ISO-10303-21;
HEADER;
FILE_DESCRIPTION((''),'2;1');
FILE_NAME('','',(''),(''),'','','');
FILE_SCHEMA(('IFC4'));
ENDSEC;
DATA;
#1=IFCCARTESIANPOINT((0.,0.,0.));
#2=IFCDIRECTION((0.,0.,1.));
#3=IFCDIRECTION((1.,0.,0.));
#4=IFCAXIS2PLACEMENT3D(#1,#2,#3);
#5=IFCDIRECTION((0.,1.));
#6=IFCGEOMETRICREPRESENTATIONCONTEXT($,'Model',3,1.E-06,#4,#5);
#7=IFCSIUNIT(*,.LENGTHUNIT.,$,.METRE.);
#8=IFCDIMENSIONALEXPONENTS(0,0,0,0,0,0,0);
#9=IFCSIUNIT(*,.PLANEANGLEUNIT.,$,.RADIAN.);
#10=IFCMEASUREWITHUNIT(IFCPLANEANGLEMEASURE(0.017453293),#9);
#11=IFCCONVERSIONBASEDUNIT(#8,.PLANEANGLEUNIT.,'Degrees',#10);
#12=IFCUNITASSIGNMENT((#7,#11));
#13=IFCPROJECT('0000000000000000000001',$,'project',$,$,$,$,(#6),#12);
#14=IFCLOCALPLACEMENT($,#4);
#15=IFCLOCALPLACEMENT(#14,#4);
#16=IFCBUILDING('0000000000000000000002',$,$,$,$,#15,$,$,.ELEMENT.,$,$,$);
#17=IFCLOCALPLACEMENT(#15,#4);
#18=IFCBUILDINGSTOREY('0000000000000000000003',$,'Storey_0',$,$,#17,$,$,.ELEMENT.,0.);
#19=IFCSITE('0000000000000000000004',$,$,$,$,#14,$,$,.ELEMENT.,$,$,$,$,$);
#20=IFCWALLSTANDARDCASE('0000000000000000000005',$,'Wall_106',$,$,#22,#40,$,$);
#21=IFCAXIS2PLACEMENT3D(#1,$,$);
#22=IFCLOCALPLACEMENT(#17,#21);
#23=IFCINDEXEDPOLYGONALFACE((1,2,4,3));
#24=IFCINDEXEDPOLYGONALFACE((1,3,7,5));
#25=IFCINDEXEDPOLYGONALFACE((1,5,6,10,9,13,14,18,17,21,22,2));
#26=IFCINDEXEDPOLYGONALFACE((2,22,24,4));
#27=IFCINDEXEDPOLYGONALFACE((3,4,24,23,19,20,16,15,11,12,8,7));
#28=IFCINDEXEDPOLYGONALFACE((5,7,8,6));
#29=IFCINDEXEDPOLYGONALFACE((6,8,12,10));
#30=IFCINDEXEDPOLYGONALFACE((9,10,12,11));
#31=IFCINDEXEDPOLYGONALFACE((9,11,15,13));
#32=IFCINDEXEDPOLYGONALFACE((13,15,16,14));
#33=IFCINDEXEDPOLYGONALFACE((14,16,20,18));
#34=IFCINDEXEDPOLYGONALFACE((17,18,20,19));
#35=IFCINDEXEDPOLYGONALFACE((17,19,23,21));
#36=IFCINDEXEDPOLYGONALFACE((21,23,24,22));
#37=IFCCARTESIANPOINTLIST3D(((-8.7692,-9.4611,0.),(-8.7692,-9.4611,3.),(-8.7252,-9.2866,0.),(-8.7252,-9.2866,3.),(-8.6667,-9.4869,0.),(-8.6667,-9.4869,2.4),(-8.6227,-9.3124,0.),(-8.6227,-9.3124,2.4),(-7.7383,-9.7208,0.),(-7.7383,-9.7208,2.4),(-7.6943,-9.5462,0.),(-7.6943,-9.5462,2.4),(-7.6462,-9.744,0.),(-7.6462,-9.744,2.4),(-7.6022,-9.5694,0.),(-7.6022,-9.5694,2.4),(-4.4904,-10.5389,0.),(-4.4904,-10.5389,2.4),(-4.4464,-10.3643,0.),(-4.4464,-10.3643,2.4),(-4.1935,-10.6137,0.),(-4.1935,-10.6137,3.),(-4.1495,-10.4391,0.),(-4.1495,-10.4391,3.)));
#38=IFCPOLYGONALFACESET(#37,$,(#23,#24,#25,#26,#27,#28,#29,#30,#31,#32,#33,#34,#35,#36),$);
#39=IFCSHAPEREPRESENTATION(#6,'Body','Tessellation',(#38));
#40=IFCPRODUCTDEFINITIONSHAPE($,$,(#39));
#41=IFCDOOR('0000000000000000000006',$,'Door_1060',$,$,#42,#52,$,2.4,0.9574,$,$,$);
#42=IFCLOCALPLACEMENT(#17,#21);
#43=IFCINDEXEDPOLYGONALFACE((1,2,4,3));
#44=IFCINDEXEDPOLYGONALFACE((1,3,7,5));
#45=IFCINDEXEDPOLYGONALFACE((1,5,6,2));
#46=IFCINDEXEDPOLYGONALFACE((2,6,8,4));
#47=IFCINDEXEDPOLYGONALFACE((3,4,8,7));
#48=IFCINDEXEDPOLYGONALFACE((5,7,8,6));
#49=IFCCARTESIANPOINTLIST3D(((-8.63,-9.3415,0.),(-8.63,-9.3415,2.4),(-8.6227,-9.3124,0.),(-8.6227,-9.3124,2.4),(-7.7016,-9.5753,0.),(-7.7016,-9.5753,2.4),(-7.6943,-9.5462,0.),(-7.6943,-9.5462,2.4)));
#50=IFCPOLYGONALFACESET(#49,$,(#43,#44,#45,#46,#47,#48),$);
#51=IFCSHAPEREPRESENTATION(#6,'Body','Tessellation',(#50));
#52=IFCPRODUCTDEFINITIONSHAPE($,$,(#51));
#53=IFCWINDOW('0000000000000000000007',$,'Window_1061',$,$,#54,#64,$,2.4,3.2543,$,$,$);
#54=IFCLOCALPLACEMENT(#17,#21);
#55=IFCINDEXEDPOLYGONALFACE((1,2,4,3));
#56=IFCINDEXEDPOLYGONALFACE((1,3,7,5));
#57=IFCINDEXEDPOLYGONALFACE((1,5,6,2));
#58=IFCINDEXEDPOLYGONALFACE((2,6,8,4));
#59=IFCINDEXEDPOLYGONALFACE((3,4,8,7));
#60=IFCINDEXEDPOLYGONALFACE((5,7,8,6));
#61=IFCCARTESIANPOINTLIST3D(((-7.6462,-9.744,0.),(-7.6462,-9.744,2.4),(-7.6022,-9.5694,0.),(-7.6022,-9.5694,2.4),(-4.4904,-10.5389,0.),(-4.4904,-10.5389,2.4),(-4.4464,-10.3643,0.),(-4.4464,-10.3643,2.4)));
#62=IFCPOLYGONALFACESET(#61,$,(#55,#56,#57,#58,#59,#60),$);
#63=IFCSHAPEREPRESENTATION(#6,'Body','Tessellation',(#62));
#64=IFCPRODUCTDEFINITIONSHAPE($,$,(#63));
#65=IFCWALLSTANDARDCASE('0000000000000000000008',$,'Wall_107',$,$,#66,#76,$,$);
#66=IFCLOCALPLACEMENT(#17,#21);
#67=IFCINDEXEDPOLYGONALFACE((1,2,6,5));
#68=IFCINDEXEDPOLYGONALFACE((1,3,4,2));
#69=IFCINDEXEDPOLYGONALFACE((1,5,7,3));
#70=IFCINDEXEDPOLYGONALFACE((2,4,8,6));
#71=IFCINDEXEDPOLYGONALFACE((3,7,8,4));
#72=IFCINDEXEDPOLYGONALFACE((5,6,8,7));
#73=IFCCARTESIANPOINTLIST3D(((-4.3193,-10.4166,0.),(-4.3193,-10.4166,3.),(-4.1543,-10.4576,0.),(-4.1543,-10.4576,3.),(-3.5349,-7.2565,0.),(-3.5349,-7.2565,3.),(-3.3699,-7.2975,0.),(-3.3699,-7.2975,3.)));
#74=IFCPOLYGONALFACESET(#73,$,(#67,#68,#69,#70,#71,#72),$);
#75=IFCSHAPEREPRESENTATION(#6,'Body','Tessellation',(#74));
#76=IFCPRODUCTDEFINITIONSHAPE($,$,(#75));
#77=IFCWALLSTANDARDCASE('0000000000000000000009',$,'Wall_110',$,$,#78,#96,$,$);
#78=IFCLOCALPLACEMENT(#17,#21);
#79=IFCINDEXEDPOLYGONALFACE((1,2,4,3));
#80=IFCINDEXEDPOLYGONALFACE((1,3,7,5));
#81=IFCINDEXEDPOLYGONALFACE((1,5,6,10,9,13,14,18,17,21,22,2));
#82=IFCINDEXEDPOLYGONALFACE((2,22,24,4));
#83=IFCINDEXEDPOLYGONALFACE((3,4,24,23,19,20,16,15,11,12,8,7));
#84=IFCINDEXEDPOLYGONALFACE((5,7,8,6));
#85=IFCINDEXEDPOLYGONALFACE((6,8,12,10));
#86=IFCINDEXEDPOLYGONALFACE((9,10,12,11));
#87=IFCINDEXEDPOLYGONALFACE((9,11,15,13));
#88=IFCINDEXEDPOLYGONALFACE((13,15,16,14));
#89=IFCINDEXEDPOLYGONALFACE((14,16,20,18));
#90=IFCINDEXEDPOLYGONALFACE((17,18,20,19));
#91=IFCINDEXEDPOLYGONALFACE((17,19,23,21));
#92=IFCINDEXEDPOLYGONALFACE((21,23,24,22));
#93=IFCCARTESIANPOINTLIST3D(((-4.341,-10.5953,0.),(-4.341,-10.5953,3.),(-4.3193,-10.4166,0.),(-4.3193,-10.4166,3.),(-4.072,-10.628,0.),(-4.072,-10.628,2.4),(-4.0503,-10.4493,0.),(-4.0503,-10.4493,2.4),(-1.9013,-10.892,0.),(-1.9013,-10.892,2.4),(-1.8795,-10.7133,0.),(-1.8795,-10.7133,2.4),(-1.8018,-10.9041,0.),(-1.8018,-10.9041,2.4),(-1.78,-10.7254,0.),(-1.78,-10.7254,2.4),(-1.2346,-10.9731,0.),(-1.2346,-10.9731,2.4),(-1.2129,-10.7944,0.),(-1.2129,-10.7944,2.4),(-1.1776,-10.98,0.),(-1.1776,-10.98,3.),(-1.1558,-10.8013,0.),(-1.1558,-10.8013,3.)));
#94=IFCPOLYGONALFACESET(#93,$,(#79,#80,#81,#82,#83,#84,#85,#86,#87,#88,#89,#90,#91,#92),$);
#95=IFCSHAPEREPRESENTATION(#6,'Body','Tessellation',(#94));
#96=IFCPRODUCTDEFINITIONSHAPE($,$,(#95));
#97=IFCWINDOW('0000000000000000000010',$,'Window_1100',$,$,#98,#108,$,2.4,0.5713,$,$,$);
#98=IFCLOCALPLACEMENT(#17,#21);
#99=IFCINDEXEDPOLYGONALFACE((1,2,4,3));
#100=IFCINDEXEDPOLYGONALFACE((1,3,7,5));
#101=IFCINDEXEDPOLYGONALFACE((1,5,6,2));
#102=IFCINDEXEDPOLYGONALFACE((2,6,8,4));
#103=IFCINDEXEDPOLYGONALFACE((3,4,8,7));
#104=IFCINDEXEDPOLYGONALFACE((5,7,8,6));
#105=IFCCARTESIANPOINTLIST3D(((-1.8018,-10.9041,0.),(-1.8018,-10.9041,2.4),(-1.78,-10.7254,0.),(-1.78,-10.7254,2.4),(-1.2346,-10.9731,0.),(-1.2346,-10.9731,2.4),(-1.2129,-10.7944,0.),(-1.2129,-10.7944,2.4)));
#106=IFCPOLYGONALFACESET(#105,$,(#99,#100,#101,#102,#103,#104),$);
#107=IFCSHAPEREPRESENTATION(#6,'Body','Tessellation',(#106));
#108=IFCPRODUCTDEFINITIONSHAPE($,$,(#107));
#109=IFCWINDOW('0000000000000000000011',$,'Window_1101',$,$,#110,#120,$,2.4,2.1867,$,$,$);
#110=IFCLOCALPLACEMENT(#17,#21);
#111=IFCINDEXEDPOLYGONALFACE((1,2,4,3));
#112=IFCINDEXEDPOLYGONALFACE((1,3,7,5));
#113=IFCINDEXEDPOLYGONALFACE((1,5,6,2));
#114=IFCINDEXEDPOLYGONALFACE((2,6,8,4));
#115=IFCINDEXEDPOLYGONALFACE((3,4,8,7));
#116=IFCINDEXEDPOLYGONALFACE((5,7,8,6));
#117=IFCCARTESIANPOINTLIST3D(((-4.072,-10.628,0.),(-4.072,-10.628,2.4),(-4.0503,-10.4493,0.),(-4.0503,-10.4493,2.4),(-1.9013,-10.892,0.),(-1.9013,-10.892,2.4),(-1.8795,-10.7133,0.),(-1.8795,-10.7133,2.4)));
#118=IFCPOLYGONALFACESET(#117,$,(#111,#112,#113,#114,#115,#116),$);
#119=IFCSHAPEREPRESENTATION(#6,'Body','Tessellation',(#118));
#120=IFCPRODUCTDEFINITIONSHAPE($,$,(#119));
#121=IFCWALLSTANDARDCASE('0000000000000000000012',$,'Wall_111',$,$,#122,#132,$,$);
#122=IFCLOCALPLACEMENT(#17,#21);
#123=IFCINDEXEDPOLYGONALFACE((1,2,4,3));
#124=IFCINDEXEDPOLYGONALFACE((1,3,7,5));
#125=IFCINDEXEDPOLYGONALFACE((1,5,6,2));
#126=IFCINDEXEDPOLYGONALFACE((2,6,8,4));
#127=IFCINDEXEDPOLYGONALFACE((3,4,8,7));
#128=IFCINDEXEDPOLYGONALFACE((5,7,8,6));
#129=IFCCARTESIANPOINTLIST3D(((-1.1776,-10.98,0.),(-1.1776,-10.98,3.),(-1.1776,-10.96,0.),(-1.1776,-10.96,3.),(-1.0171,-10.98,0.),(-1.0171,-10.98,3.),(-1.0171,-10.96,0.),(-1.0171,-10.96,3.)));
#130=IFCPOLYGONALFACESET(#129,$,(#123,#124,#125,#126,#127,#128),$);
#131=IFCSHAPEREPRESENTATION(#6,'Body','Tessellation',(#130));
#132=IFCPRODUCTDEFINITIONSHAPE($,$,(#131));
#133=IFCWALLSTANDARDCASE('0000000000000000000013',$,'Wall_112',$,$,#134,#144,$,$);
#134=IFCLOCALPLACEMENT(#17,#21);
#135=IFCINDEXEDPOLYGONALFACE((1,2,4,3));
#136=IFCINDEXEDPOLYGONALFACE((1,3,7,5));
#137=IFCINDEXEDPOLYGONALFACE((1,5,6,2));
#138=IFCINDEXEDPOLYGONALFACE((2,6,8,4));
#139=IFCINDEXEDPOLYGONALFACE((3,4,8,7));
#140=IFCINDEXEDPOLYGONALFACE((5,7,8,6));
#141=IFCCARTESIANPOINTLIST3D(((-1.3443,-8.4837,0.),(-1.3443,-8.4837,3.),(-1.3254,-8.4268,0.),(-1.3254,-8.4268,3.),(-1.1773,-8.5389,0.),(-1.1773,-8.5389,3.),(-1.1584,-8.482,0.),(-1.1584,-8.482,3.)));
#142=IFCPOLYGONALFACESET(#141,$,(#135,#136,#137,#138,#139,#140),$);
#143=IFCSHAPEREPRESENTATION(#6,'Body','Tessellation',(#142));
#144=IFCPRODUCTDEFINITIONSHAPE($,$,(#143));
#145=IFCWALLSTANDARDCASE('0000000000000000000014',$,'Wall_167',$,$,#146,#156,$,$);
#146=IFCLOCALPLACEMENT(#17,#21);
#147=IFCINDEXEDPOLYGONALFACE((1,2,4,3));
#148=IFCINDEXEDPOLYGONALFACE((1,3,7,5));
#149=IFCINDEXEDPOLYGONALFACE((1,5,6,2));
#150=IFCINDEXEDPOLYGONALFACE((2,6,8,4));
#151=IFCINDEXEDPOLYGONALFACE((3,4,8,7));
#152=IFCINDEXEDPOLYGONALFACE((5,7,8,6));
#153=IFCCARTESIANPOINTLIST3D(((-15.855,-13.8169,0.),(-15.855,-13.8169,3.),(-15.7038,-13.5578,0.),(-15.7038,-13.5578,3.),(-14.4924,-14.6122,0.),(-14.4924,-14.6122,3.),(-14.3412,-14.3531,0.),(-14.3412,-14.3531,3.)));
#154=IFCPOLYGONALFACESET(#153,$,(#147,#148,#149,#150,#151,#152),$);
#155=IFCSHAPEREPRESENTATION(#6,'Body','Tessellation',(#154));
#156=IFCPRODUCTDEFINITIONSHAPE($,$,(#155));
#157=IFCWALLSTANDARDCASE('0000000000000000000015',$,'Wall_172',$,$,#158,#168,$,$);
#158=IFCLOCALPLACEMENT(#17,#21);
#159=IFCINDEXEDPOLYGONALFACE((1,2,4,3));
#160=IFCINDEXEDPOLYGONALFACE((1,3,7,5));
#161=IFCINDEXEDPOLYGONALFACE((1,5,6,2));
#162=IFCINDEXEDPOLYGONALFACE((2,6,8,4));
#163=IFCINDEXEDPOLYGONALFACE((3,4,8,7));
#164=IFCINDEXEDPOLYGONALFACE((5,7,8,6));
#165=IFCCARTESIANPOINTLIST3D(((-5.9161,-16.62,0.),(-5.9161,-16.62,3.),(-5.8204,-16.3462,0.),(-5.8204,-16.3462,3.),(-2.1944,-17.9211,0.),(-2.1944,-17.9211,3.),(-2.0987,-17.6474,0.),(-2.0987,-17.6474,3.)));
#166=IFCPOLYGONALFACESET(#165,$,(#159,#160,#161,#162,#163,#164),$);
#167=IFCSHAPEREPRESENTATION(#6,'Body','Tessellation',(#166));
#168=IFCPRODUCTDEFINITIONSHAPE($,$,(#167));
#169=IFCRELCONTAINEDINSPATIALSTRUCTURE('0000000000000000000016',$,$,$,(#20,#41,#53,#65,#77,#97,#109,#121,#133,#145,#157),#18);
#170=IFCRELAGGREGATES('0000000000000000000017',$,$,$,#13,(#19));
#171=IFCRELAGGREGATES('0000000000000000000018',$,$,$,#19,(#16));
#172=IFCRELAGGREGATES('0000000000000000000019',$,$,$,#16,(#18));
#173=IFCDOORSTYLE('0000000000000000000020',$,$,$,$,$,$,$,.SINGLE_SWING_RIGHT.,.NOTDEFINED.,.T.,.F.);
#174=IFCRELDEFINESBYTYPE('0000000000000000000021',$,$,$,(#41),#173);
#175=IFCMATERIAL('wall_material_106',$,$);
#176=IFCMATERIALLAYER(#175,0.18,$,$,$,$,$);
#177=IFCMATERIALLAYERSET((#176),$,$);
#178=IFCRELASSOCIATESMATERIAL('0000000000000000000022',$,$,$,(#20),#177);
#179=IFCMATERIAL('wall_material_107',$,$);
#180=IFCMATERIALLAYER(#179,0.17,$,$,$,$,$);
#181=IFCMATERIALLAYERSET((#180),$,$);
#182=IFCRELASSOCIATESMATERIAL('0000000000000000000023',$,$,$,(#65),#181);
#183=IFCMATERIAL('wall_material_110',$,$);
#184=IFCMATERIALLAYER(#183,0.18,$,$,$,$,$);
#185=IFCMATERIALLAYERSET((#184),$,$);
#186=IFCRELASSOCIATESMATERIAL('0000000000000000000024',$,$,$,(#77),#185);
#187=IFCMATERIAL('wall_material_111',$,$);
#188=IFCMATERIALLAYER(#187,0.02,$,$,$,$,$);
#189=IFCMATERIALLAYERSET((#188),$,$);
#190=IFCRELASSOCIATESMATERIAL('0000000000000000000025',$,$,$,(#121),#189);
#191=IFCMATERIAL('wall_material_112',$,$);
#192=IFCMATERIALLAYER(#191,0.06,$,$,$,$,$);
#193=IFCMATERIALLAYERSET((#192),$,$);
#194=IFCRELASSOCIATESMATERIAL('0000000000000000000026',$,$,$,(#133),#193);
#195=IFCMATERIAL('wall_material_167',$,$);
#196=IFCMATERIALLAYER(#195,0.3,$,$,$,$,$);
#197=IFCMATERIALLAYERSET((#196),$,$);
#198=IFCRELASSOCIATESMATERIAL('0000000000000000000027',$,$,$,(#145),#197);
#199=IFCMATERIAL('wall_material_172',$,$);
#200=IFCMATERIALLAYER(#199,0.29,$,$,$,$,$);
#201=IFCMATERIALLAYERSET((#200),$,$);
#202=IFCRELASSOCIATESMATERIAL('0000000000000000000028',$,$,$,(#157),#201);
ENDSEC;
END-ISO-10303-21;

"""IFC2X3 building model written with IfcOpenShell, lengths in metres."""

from ifc_helpers import new_model, entity, si_unit, converted_unit, direction, frame, frame_2d, origin_with_axes, place, context, project, spatial, polyline, rectangle, outline, extrude, material, layer, layer_set, layer_usage, type_object, element, fill, save


model = new_model("IFC2X3")

# Units and contexts
model_context = context("Model", 3, precision=1e-06, world=origin_with_axes(), true_north=direction((0.0, 1.0)))
ifc_project = project(units=[si_unit("LENGTHUNIT", "METRE"), converted_unit("PLANEANGLEUNIT", "Degrees", entity("IfcPlaneAngleMeasure", 0.017453293), si_unit("PLANEANGLEUNIT", "RADIAN"), dimensions=[0, 0, 0, 0, 0, 0, 0])], contexts=[model_context])

# Site, building, storey
site_placement = place(None, origin_with_axes())
site = spatial("IfcSite", under=ifc_project, at=site_placement, CompositionType="ELEMENT")
building_placement = place(site_placement, origin_with_axes())
building = spatial("IfcBuilding", under=site, at=building_placement, CompositionType="ELEMENT")
storey_placement = place(building_placement, origin_with_axes())
storey = spatial("IfcBuildingStorey", under=building, at=storey_placement, Name="Storey_0", CompositionType="ELEMENT", Elevation=0.0)

# Wall, openings, door, window
ifc_material_1 = material(Name="wall_material_106")
ifc_layer_1 = layer(ifc_material_1, 0.18)
ifc_layer_set_1 = layer_set([ifc_layer_1])
ifc_layer_usage_1 = layer_usage(ifc_layer_set_1, "AXIS2", "POSITIVE", 0.0)
wall_1_placement = place(storey_placement, frame((-8.7692, -9.4611, 0.0), z_axis=(0.0, 0.0, 1.0), x_axis=(0.96971, -0.244257, 0.0)))
wall_1 = element("IfcWallStandardCase", 1, at=wall_1_placement, inside=storey, material=ifc_layer_usage_1, Name="Wall_106", context=model_context, shape_type="SweptSolid", body=[
    extrude(outline(polyline([(0.0, 0.18), (4.7186, 0.18), (4.7186, 0.0), (0.0, 0.0), (0.0, 0.18)])), origin_with_axes(), (0.0, 0.0, 1.0), 3.0),
])
opening_1_placement = place(wall_1_placement, frame((0.1057, 0.18, 0.0), z_axis=(0.0, 0.0, 1.0), x_axis=(1.0, 0.0, 0.0)))
opening_1 = element("IfcOpeningElement", 2, at=opening_1_placement, cuts=wall_1, context=model_context, shape_type="SweptSolid", body=[
    extrude(rectangle(XDim=0.9574, YDim=2.4, at=frame_2d((1.2, -0.4787), x_axis=(0.0, 1.0))), frame((0.0, 0.01, 0.0), z_axis=(0.0, -1.0, 0.0), x_axis=(0.0, 0.0, 1.0)), (0.0, 0.0, 1.0), 0.2),
])
opening_2_placement = place(wall_1_placement, frame((1.1581, 0.18, 0.0), z_axis=(0.0, 0.0, 1.0), x_axis=(1.0, 0.0, 0.0)))
opening_2 = element("IfcOpeningElement", 3, at=opening_2_placement, cuts=wall_1, context=model_context, shape_type="SweptSolid", body=[
    extrude(rectangle(XDim=3.2543, YDim=2.4, at=frame_2d((1.2, -1.6272), x_axis=(0.0, 1.0))), frame((0.0, 0.01, 0.0), z_axis=(0.0, -1.0, 0.0), x_axis=(0.0, 0.0, 1.0)), (0.0, 0.0, 1.0), 0.2),
])
door_style_1 = type_object("IfcDoorStyle", ConstructionType="NOTDEFINED", OperationType="SINGLE_SWING_RIGHT", ParameterTakesPrecedence=True, Sizeable=False)
door_1_placement = place(storey_placement, origin_with_axes())
door_1 = element("IfcDoor", 4, at=door_1_placement, inside=storey, type_object=door_style_1, Name="Door_1060", OverallHeight=2.4, OverallWidth=0.9574, context=model_context, shape_type="SweptSolid", body=[
    extrude(outline(polyline([(-8.6227, -9.3124), (-7.6943, -9.5462), (-7.7016, -9.5753), (-8.63, -9.3415), (-8.6227, -9.3124)])), origin_with_axes(), (0.0, 0.0, 1.0), 2.4),
])
fill(opening_1, door_1)
window_1_placement = place(storey_placement, origin_with_axes())
window_1 = element("IfcWindow", 5, at=window_1_placement, inside=storey, Name="Window_1061", OverallHeight=2.4, OverallWidth=3.2543, context=model_context, shape_type="SweptSolid", body=[
    extrude(outline(polyline([(-7.6022, -9.5694), (-4.4464, -10.3643), (-4.4904, -10.5389), (-7.6462, -9.744), (-7.6022, -9.5694)])), origin_with_axes(), (0.0, 0.0, 1.0), 2.4),
])
fill(opening_2, window_1)

# Wall
ifc_material_2 = material(Name="wall_material_107")
ifc_layer_2 = layer(ifc_material_2, 0.17)
ifc_layer_set_2 = layer_set([ifc_layer_2])
ifc_layer_usage_2 = layer_usage(ifc_layer_set_2, "AXIS2", "POSITIVE", 0.0)
wall_2_placement = place(storey_placement, frame((-4.1543, -10.4576, 0.0), z_axis=(0.0, 0.0, 1.0), x_axis=(0.240906, 0.970549, 0.0)))
element("IfcWallStandardCase", 6, at=wall_2_placement, inside=storey, material=ifc_layer_usage_2, Name="Wall_107", context=model_context, shape_type="SweptSolid", body=[
    extrude(outline(polyline([(0.0, 0.17), (3.256, 0.17), (3.256, 0.0), (0.0, 0.0), (0.0, 0.17)])), origin_with_axes(), (0.0, 0.0, 1.0), 3.0),
])

# Wall, openings, windows
ifc_material_3 = material(Name="wall_material_110")
ifc_layer_3 = layer(ifc_material_3, 0.18)
ifc_layer_set_3 = layer_set([ifc_layer_3])
ifc_layer_usage_3 = layer_usage(ifc_layer_set_3, "AXIS2", "NEGATIVE", 0.0)
wall_3_placement = place(storey_placement, frame((-1.1776, -10.98, 0.0), z_axis=(0.0, 0.0, 1.0), x_axis=(-0.992687, 0.12072, 0.0)))
wall_3 = element("IfcWallStandardCase", 7, at=wall_3_placement, inside=storey, material=ifc_layer_usage_3, Name="Wall_110", context=model_context, shape_type="SweptSolid", body=[
    extrude(outline(polyline([(0.0, 0.0), (3.1868, 0.0), (3.1868, -0.18), (0.0, -0.18), (0.0, 0.0)])), origin_with_axes(), (0.0, 0.0, 1.0), 3.0),
])
opening_3_placement = place(wall_3_placement, frame((0.0575, 0.0, 0.0), z_axis=(0.0, 0.0, 1.0), x_axis=(1.0, 0.0, 0.0)))
opening_3 = element("IfcOpeningElement", 8, at=opening_3_placement, cuts=wall_3, context=model_context, shape_type="SweptSolid", body=[
    extrude(rectangle(XDim=0.5713, YDim=2.4, at=frame_2d((1.2, -0.2857), x_axis=(0.0, 1.0))), frame((0.0, 0.01, 0.0), z_axis=(0.0, -1.0, 0.0), x_axis=(0.0, 0.0, 1.0)), (0.0, 0.0, 1.0), 0.2),
])
opening_4_placement = place(wall_3_placement, frame((0.729, 0.0, 0.0), z_axis=(0.0, 0.0, 1.0), x_axis=(1.0, 0.0, 0.0)))
opening_4 = element("IfcOpeningElement", 9, at=opening_4_placement, cuts=wall_3, context=model_context, shape_type="SweptSolid", body=[
    extrude(rectangle(XDim=2.1867, YDim=2.4, at=frame_2d((1.2, -1.0934), x_axis=(0.0, 1.0))), frame((0.0, 0.01, 0.0), z_axis=(0.0, -1.0, 0.0), x_axis=(0.0, 0.0, 1.0)), (0.0, 0.0, 1.0), 0.2),
])
window_2_placement = place(storey_placement, origin_with_axes())
window_2 = element("IfcWindow", 10, at=window_2_placement, inside=storey, Name="Window_1100", OverallHeight=2.4, OverallWidth=0.5713, context=model_context, shape_type="SweptSolid", body=[
    extrude(outline(polyline([(-1.2346, -10.9731), (-1.8018, -10.9041), (-1.78, -10.7254), (-1.2129, -10.7944), (-1.2346, -10.9731)])), origin_with_axes(), (0.0, 0.0, 1.0), 2.4),
])
fill(opening_3, window_2)
window_3_placement = place(storey_placement, origin_with_axes())
window_3 = element("IfcWindow", 11, at=window_3_placement, inside=storey, Name="Window_1101", OverallHeight=2.4, OverallWidth=2.1867, context=model_context, shape_type="SweptSolid", body=[
    extrude(outline(polyline([(-1.9013, -10.892), (-4.072, -10.628), (-4.0503, -10.4493), (-1.8795, -10.7133), (-1.9013, -10.892)])), origin_with_axes(), (0.0, 0.0, 1.0), 2.4),
])
fill(opening_4, window_3)

# Walls
ifc_material_4 = material(Name="wall_material_111")
ifc_layer_4 = layer(ifc_material_4, 0.02)
ifc_layer_set_4 = layer_set([ifc_layer_4])
ifc_layer_usage_4 = layer_usage(ifc_layer_set_4, "AXIS2", "POSITIVE", 0.0)
wall_4_placement = place(storey_placement, frame((-1.1776, -10.98, 0.0), z_axis=(0.0, 0.0, 1.0), x_axis=(1.0, 0.0, 0.0)))
element("IfcWallStandardCase", 12, at=wall_4_placement, inside=storey, material=ifc_layer_usage_4, Name="Wall_111", context=model_context, shape_type="SweptSolid", body=[
    extrude(outline(polyline([(0.0, 0.02), (0.1605, 0.02), (0.1605, 0.0), (0.0, 0.0), (0.0, 0.02)])), origin_with_axes(), (0.0, 0.0, 1.0), 3.0),
])
ifc_material_5 = material(Name="wall_material_112")
ifc_layer_5 = layer(ifc_material_5, 0.06)
ifc_layer_set_5 = layer_set([ifc_layer_5])
ifc_layer_usage_5 = layer_usage(ifc_layer_set_5, "AXIS2", "POSITIVE", 0.0)
wall_5_placement = place(storey_placement, frame((-1.3443, -8.4837, 0.0), z_axis=(0.0, 0.0, 1.0), x_axis=(0.94947, -0.313859, 0.0)))
element("IfcWallStandardCase", 13, at=wall_5_placement, inside=storey, material=ifc_layer_usage_5, Name="Wall_112", context=model_context, shape_type="SweptSolid", body=[
    extrude(outline(polyline([(0.0, 0.06), (0.1759, 0.06), (0.1759, 0.0), (0.0, 0.0), (0.0, 0.06)])), origin_with_axes(), (0.0, 0.0, 1.0), 3.0),
])
ifc_material_6 = material(Name="wall_material_167")
ifc_layer_6 = layer(ifc_material_6, 0.3)
ifc_layer_set_6 = layer_set([ifc_layer_6])
ifc_layer_usage_6 = layer_usage(ifc_layer_set_6, "AXIS2", "NEGATIVE", 0.0)
wall_6_placement = place(storey_placement, frame((-14.4924, -14.6122, 0.0), z_axis=(0.0, 0.0, 1.0), x_axis=(-0.86366, 0.504075, 0.0)))
element("IfcWallStandardCase", 14, at=wall_6_placement, inside=storey, material=ifc_layer_usage_6, Name="Wall_167", context=model_context, shape_type="SweptSolid", body=[
    extrude(outline(polyline([(0.0, 0.0), (1.5777, 0.0), (1.5777, -0.3), (0.0, -0.3), (0.0, 0.0)])), origin_with_axes(), (0.0, 0.0, 1.0), 3.0),
])
ifc_material_7 = material(Name="wall_material_172")
ifc_layer_7 = layer(ifc_material_7, 0.29)
ifc_layer_set_7 = layer_set([ifc_layer_7])
ifc_layer_usage_7 = layer_usage(ifc_layer_set_7, "AXIS2", "NEGATIVE", 0.0)
wall_7_placement = place(storey_placement, frame((-2.1944, -17.9211, 0.0), z_axis=(0.0, 0.0, 1.0), x_axis=(-0.943974, 0.33002, 0.0)))
element("IfcWallStandardCase", 15, at=wall_7_placement, inside=storey, material=ifc_layer_usage_7, Name="Wall_172", context=model_context, shape_type="SweptSolid", body=[
    extrude(outline(polyline([(0.0, 0.0), (3.9427, 0.0), (3.9427, -0.29), (0.0, -0.29), (0.0, 0.0)])), origin_with_axes(), (0.0, 0.0, 1.0), 3.0),
])

save(model, "model.ifc")
